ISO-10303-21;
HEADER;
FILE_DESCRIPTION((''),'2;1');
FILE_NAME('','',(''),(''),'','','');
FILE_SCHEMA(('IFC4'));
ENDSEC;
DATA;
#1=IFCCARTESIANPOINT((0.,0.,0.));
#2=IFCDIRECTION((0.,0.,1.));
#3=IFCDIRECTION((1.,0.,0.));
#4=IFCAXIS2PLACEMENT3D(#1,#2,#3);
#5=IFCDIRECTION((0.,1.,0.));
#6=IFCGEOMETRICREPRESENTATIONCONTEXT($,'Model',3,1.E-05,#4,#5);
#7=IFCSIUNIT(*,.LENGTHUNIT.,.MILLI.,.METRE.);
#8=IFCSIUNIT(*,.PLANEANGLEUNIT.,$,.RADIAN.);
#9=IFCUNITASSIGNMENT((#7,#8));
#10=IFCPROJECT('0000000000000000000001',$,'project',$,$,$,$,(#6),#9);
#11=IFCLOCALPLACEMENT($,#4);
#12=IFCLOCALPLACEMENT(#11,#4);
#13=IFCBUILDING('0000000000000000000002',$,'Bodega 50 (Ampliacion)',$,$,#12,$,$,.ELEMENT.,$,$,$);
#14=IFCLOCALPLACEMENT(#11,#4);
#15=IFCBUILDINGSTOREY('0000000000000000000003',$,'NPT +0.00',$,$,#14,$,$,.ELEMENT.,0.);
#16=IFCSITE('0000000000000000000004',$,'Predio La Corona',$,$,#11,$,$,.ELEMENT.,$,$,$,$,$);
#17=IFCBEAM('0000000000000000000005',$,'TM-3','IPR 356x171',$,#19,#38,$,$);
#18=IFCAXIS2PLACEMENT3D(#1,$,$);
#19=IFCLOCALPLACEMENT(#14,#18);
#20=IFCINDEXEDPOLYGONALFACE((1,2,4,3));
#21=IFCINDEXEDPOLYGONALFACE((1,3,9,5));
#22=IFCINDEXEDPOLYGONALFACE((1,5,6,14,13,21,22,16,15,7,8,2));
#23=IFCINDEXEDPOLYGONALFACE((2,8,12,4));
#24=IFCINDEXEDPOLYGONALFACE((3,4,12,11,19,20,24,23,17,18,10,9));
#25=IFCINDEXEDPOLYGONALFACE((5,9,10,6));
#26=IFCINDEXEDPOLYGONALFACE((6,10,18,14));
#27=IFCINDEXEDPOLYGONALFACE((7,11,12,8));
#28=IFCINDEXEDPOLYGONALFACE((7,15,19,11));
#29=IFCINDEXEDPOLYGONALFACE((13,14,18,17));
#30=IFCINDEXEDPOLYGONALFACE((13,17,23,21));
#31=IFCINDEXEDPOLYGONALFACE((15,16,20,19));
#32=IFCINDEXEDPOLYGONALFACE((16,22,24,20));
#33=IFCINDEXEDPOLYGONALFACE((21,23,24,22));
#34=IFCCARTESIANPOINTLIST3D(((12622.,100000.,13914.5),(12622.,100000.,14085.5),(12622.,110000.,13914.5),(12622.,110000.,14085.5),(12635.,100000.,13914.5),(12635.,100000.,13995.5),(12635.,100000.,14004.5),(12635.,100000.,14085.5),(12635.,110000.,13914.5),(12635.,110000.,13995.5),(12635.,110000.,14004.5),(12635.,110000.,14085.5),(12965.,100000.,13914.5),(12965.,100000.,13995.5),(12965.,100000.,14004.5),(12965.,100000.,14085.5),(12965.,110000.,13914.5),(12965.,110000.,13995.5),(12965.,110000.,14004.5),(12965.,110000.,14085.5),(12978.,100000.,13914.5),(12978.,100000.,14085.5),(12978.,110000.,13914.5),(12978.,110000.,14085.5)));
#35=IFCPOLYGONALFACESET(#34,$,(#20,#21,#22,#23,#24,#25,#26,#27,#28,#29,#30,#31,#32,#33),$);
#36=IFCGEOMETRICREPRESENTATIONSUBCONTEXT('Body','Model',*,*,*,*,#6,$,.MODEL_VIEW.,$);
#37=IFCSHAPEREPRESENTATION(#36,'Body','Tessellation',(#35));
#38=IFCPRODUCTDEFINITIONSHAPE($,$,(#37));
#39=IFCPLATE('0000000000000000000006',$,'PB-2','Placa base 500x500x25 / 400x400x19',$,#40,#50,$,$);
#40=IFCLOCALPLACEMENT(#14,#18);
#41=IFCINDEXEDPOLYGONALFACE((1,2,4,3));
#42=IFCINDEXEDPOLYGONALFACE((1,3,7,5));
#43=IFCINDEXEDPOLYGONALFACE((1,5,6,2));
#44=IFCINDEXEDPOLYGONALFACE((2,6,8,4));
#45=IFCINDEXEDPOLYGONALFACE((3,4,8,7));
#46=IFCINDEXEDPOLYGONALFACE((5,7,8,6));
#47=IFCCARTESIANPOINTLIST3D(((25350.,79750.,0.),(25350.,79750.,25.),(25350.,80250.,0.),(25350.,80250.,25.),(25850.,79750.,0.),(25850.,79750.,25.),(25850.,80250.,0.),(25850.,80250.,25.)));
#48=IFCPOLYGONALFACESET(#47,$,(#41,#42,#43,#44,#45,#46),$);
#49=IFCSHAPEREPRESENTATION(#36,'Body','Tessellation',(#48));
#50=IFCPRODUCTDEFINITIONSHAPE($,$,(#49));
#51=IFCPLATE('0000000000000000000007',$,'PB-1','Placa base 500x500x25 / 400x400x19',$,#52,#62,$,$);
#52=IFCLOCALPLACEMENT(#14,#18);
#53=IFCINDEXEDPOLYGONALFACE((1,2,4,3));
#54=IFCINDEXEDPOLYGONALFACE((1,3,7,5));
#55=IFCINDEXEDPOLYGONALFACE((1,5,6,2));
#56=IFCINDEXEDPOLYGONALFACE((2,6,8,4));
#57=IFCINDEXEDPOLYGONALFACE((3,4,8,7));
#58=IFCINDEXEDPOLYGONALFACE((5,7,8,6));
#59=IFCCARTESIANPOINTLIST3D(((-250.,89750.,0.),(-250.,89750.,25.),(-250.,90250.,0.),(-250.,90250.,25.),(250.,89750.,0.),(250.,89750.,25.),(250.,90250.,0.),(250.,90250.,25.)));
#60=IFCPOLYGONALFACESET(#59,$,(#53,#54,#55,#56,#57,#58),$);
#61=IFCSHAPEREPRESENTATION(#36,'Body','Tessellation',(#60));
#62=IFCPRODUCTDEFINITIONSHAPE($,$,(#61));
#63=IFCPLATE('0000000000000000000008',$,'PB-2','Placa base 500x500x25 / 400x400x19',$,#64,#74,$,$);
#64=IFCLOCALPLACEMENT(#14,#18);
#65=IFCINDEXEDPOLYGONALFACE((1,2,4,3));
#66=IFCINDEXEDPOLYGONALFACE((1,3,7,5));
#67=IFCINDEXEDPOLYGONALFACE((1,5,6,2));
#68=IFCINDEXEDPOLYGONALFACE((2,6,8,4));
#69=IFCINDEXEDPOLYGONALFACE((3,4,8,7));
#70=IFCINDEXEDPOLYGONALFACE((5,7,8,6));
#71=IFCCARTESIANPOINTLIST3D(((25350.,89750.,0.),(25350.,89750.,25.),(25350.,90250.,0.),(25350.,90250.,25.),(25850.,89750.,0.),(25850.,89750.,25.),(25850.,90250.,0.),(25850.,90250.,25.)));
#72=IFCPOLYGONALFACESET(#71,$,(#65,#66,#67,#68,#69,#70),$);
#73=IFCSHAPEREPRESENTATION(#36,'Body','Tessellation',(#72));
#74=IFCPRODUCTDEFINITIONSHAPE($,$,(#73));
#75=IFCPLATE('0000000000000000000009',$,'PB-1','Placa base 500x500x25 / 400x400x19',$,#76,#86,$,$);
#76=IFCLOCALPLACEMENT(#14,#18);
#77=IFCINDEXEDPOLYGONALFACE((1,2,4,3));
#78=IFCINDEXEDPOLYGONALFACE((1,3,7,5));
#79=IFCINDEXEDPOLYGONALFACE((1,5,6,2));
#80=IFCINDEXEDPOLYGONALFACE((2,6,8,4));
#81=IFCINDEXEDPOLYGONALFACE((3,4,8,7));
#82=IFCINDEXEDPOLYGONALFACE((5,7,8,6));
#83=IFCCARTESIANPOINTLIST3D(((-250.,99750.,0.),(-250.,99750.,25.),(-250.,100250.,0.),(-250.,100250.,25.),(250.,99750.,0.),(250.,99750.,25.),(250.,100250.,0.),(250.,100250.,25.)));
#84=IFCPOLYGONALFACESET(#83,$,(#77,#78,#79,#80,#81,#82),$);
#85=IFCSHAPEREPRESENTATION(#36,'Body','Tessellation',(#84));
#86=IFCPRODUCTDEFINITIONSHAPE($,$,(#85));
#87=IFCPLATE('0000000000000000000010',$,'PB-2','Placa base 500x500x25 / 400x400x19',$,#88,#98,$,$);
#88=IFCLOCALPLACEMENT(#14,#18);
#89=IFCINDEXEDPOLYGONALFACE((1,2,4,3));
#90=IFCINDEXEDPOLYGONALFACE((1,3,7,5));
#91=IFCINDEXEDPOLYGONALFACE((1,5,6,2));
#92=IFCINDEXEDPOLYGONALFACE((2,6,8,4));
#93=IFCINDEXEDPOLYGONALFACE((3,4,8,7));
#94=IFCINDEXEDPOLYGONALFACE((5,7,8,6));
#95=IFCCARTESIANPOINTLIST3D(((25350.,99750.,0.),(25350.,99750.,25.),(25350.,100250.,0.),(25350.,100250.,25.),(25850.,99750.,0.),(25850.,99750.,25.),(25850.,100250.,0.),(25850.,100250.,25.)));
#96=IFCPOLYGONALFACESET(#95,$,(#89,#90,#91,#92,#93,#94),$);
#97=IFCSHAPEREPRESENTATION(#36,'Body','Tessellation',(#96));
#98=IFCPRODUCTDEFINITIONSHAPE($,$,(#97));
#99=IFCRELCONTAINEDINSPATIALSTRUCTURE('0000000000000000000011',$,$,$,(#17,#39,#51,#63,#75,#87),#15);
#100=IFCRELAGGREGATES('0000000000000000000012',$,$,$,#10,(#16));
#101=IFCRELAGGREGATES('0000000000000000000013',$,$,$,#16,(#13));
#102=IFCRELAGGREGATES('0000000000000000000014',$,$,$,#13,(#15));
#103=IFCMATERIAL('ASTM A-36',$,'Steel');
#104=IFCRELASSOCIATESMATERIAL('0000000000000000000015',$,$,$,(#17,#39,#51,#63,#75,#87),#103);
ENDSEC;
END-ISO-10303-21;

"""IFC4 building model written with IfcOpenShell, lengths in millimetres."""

from ifc_helpers import new_model, si_unit, direction, frame, origin_with_axes, origin_2d, place, context, subcontext, project, spatial, rectangle, i_section, extrude, material, element, save


model = new_model("IFC4")

# Units and contexts
model_context = context("Model", 3, precision=1e-05, world=origin_with_axes(), true_north=direction((0.0, 1.0, 0.0)))
body_context = subcontext(model_context, "Body", "Model", "MODEL_VIEW")
ifc_project = project(units=[si_unit("LENGTHUNIT", "METRE", prefix="MILLI"), si_unit("PLANEANGLEUNIT", "RADIAN")], contexts=[model_context])

# Site, building, storey
site_placement = place(None, origin_with_axes())
site = spatial("IfcSite", under=ifc_project, at=site_placement, Name="Predio La Corona", CompositionType="ELEMENT")
building_placement = place(site_placement, origin_with_axes())
building = spatial("IfcBuilding", under=site, at=building_placement, Name="Bodega 50 (Ampliacion)", CompositionType="ELEMENT")
storey_placement = place(site_placement, origin_with_axes())
storey = spatial("IfcBuildingStorey", under=building, at=storey_placement, Name="NPT +0.00", CompositionType="ELEMENT", Elevation=0.0)

# Shared definitions
ifc_material = material(Name="ASTM A-36", Category="Steel")

# Beam
for number, where, z_axis, x_axis, name in (
    (1, (12800.0, 100000.0, 14000.0), (0.0, 1.0, 0.0), (0.0, 0.0, 1.0), "TM-3"),
):
    element("IfcBeam", number, at=place(storey_placement, frame(where, z_axis=z_axis, x_axis=x_axis)), inside=storey, material=ifc_material, Name=name, Description="IPR 356x171", context=body_context, shape_type="SweptSolid", body=[
        extrude(i_section(OverallWidth=171.0, OverallDepth=356.0, WebThickness=9.0, FlangeThickness=13.0, at=origin_2d()), origin_with_axes(), (0.0, 0.0, 1.0), 10000.0),
    ])

# Plates
for number, where, z_axis, x_axis, name in (
    (2, (25600.0, 80000.0, 0.0), (0.0, 0.0, 1.0), (1.0, 0.0, 0.0), "PB-2"),
    (3, (0.0, 90000.0, 0.0), (0.0, 0.0, 1.0), (1.0, 0.0, 0.0), "PB-1"),
    (4, (25600.0, 90000.0, 0.0), (0.0, 0.0, 1.0), (1.0, 0.0, 0.0), "PB-2"),
    (5, (0.0, 100000.0, 0.0), (0.0, 0.0, 1.0), (1.0, 0.0, 0.0), "PB-1"),
    (6, (25600.0, 100000.0, 0.0), (0.0, 0.0, 1.0), (1.0, 0.0, 0.0), "PB-2"),
):
    element("IfcPlate", number, at=place(storey_placement, frame(where, z_axis=z_axis, x_axis=x_axis)), inside=storey, material=ifc_material, Name=name, Description="Placa base 500x500x25 / 400x400x19", context=body_context, shape_type="SweptSolid", body=[
        extrude(rectangle(XDim=500.0, YDim=500.0, at=origin_2d()), origin_with_axes(), (0.0, 0.0, 1.0), 25.0),
    ])

save(model, "model.ifc")
